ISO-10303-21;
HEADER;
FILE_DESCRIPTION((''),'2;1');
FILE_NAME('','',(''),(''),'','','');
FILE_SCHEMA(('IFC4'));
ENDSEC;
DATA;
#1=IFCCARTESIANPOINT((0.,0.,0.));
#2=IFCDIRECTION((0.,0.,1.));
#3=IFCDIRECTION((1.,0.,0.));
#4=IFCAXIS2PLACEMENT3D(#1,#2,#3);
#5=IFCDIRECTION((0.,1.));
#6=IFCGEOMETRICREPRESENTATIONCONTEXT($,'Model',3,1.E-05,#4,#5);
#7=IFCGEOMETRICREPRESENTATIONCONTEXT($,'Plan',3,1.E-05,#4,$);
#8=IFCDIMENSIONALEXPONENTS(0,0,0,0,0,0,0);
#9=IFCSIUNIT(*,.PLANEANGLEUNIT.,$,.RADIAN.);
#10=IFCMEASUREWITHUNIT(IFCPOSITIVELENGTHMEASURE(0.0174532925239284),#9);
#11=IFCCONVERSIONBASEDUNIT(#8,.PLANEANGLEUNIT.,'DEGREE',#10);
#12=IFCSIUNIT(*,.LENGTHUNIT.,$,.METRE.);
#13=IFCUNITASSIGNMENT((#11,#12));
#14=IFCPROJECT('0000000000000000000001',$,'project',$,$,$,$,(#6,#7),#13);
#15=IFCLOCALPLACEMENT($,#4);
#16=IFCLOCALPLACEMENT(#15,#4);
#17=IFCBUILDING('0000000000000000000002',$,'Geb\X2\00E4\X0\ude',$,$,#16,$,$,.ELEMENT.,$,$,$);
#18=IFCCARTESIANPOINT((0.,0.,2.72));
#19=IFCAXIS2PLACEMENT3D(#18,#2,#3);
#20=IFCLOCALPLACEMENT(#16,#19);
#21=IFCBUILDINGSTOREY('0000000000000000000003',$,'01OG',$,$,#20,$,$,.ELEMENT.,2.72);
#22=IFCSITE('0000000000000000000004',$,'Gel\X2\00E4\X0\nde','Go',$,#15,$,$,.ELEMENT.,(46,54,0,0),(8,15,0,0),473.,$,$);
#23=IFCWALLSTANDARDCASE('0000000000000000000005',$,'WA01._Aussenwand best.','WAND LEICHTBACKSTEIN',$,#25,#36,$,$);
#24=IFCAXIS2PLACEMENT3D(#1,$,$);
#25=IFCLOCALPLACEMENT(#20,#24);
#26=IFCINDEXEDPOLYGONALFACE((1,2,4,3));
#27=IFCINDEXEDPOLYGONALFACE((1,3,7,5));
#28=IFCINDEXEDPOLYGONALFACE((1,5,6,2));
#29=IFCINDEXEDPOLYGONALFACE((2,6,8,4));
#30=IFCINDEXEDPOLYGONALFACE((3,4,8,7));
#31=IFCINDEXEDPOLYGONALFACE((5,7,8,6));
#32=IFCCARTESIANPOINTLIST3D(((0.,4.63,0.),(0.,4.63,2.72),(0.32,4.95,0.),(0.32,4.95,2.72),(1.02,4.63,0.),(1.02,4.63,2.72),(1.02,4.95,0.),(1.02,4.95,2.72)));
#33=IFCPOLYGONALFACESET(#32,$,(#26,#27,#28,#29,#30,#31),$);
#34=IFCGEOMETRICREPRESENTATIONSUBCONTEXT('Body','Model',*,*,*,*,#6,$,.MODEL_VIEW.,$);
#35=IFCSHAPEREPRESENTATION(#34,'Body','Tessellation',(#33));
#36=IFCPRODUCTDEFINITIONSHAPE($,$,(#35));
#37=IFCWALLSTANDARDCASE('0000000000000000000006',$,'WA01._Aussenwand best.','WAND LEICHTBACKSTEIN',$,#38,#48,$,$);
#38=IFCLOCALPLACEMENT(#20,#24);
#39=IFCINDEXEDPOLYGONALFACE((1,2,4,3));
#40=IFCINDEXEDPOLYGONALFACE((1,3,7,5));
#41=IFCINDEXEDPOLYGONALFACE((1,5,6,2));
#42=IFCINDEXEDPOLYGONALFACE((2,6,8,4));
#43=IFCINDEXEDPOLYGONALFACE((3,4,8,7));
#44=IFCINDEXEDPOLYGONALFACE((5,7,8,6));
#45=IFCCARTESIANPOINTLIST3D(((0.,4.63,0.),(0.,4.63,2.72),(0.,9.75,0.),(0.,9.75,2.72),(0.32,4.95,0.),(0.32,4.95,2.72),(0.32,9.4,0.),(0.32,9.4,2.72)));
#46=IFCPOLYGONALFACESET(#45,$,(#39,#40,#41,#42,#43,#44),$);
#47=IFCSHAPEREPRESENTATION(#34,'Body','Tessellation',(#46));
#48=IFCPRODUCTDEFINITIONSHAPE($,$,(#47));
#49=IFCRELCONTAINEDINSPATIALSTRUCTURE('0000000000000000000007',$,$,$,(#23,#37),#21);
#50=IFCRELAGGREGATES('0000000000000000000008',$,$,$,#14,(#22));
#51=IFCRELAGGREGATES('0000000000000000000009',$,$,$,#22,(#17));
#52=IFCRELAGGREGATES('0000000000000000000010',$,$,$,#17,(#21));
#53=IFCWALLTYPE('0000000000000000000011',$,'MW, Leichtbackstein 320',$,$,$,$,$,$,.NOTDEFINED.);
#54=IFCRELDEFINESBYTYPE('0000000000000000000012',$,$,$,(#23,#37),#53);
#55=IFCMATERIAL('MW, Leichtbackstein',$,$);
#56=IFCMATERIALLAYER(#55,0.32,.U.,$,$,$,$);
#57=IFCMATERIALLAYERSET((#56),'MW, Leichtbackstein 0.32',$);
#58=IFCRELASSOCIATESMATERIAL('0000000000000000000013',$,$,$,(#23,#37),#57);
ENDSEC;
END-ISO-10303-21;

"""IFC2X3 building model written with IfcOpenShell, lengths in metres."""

from ifc_helpers import new_model, entity, si_unit, converted_unit, direction, frame, origin_with_axes, place, context, subcontext, project, spatial, polyline, outline, extrude, material, layer, layer_set, layer_usage, type_object, element, save


model = new_model("IFC2X3")

# Units and contexts
model_context = context("Model", 3, precision=1e-05, world=origin_with_axes(), true_north=direction((0.0, 1.0)))
plan_context = context("Plan", 3, precision=1e-05, world=origin_with_axes())
body_context = subcontext(model_context, "Body", "Model", "MODEL_VIEW")
ifc_project = project(units=[converted_unit("PLANEANGLEUNIT", "DEGREE", entity("IfcPositiveLengthMeasure", 0.0174532925239284), si_unit("PLANEANGLEUNIT", "RADIAN"), dimensions=[0, 0, 0, 0, 0, 0, 0]), si_unit("LENGTHUNIT", "METRE")], contexts=[model_context, plan_context])

# Site, building, storey
site_placement = place(None, origin_with_axes())
site = spatial("IfcSite", under=ifc_project, at=site_placement, Name="Gelände", Description="Go", CompositionType="ELEMENT", RefLatitude=(46, 54, 0, 0), RefLongitude=(8, 15, 0, 0), RefElevation=473.0)
building_placement = place(site_placement, origin_with_axes())
building = spatial("IfcBuilding", under=site, at=building_placement, Name="Gebäude", CompositionType="ELEMENT")
storey_placement = place(building_placement, frame((0.0, 0.0, 2.72), z_axis=(0.0, 0.0, 1.0), x_axis=(1.0, 0.0, 0.0)))
storey = spatial("IfcBuildingStorey", under=building, at=storey_placement, Name="01OG", CompositionType="ELEMENT", Elevation=2.72)

# Walls
ifc_material_1 = material(Name="MW, Leichtbackstein")
ifc_layer_1 = layer(ifc_material_1, 0.32, ventilated="UNKNOWN")
ifc_layer_set_1 = layer_set([ifc_layer_1], Name="MW, Leichtbackstein 0.32")
wall_type_1 = type_object("IfcWallType", Name="MW, Leichtbackstein 320", PredefinedType="NOTDEFINED")
ifc_layer_usage_1 = layer_usage(ifc_layer_set_1, "AXIS2", "POSITIVE", -0.32)
wall_1_placement = place(storey_placement, frame((0.32, 4.95, 0.0), z_axis=(0.0, 0.0, 1.0), x_axis=(1.0, 0.0, 0.0)))
element("IfcWallStandardCase", 1, at=wall_1_placement, inside=storey, type_object=wall_type_1, material=ifc_layer_usage_1, Name="WA01._Aussenwand best.", Description="WAND LEICHTBACKSTEIN", context=body_context, shape_type="SweptSolid", body=[
    extrude(outline(polyline([(-0.32, -0.32), (0.7, -0.32), (0.7, 0.0), (0.0, 0.0), (-0.32, -0.32)])), origin_with_axes(), (0.0, 0.0, 1.0), 2.72),
])
ifc_layer_usage_2 = layer_usage(ifc_layer_set_1, "AXIS2", "POSITIVE", -0.32)
wall_2_placement = place(storey_placement, frame((0.32, 9.4, 0.0), z_axis=(0.0, 0.0, 1.0), x_axis=(0.0, -1.0, 0.0)))
element("IfcWallStandardCase", 2, at=wall_2_placement, inside=storey, type_object=wall_type_1, material=ifc_layer_usage_2, Name="WA01._Aussenwand best.", Description="WAND LEICHTBACKSTEIN", context=body_context, shape_type="SweptSolid", body=[
    extrude(outline(polyline([(-0.35, -0.32), (4.77, -0.32), (4.45, 0.0), (0.0, 0.0), (-0.35, -0.32)])), origin_with_axes(), (0.0, 0.0, 1.0), 2.72),
])

save(model, "model.ifc")
